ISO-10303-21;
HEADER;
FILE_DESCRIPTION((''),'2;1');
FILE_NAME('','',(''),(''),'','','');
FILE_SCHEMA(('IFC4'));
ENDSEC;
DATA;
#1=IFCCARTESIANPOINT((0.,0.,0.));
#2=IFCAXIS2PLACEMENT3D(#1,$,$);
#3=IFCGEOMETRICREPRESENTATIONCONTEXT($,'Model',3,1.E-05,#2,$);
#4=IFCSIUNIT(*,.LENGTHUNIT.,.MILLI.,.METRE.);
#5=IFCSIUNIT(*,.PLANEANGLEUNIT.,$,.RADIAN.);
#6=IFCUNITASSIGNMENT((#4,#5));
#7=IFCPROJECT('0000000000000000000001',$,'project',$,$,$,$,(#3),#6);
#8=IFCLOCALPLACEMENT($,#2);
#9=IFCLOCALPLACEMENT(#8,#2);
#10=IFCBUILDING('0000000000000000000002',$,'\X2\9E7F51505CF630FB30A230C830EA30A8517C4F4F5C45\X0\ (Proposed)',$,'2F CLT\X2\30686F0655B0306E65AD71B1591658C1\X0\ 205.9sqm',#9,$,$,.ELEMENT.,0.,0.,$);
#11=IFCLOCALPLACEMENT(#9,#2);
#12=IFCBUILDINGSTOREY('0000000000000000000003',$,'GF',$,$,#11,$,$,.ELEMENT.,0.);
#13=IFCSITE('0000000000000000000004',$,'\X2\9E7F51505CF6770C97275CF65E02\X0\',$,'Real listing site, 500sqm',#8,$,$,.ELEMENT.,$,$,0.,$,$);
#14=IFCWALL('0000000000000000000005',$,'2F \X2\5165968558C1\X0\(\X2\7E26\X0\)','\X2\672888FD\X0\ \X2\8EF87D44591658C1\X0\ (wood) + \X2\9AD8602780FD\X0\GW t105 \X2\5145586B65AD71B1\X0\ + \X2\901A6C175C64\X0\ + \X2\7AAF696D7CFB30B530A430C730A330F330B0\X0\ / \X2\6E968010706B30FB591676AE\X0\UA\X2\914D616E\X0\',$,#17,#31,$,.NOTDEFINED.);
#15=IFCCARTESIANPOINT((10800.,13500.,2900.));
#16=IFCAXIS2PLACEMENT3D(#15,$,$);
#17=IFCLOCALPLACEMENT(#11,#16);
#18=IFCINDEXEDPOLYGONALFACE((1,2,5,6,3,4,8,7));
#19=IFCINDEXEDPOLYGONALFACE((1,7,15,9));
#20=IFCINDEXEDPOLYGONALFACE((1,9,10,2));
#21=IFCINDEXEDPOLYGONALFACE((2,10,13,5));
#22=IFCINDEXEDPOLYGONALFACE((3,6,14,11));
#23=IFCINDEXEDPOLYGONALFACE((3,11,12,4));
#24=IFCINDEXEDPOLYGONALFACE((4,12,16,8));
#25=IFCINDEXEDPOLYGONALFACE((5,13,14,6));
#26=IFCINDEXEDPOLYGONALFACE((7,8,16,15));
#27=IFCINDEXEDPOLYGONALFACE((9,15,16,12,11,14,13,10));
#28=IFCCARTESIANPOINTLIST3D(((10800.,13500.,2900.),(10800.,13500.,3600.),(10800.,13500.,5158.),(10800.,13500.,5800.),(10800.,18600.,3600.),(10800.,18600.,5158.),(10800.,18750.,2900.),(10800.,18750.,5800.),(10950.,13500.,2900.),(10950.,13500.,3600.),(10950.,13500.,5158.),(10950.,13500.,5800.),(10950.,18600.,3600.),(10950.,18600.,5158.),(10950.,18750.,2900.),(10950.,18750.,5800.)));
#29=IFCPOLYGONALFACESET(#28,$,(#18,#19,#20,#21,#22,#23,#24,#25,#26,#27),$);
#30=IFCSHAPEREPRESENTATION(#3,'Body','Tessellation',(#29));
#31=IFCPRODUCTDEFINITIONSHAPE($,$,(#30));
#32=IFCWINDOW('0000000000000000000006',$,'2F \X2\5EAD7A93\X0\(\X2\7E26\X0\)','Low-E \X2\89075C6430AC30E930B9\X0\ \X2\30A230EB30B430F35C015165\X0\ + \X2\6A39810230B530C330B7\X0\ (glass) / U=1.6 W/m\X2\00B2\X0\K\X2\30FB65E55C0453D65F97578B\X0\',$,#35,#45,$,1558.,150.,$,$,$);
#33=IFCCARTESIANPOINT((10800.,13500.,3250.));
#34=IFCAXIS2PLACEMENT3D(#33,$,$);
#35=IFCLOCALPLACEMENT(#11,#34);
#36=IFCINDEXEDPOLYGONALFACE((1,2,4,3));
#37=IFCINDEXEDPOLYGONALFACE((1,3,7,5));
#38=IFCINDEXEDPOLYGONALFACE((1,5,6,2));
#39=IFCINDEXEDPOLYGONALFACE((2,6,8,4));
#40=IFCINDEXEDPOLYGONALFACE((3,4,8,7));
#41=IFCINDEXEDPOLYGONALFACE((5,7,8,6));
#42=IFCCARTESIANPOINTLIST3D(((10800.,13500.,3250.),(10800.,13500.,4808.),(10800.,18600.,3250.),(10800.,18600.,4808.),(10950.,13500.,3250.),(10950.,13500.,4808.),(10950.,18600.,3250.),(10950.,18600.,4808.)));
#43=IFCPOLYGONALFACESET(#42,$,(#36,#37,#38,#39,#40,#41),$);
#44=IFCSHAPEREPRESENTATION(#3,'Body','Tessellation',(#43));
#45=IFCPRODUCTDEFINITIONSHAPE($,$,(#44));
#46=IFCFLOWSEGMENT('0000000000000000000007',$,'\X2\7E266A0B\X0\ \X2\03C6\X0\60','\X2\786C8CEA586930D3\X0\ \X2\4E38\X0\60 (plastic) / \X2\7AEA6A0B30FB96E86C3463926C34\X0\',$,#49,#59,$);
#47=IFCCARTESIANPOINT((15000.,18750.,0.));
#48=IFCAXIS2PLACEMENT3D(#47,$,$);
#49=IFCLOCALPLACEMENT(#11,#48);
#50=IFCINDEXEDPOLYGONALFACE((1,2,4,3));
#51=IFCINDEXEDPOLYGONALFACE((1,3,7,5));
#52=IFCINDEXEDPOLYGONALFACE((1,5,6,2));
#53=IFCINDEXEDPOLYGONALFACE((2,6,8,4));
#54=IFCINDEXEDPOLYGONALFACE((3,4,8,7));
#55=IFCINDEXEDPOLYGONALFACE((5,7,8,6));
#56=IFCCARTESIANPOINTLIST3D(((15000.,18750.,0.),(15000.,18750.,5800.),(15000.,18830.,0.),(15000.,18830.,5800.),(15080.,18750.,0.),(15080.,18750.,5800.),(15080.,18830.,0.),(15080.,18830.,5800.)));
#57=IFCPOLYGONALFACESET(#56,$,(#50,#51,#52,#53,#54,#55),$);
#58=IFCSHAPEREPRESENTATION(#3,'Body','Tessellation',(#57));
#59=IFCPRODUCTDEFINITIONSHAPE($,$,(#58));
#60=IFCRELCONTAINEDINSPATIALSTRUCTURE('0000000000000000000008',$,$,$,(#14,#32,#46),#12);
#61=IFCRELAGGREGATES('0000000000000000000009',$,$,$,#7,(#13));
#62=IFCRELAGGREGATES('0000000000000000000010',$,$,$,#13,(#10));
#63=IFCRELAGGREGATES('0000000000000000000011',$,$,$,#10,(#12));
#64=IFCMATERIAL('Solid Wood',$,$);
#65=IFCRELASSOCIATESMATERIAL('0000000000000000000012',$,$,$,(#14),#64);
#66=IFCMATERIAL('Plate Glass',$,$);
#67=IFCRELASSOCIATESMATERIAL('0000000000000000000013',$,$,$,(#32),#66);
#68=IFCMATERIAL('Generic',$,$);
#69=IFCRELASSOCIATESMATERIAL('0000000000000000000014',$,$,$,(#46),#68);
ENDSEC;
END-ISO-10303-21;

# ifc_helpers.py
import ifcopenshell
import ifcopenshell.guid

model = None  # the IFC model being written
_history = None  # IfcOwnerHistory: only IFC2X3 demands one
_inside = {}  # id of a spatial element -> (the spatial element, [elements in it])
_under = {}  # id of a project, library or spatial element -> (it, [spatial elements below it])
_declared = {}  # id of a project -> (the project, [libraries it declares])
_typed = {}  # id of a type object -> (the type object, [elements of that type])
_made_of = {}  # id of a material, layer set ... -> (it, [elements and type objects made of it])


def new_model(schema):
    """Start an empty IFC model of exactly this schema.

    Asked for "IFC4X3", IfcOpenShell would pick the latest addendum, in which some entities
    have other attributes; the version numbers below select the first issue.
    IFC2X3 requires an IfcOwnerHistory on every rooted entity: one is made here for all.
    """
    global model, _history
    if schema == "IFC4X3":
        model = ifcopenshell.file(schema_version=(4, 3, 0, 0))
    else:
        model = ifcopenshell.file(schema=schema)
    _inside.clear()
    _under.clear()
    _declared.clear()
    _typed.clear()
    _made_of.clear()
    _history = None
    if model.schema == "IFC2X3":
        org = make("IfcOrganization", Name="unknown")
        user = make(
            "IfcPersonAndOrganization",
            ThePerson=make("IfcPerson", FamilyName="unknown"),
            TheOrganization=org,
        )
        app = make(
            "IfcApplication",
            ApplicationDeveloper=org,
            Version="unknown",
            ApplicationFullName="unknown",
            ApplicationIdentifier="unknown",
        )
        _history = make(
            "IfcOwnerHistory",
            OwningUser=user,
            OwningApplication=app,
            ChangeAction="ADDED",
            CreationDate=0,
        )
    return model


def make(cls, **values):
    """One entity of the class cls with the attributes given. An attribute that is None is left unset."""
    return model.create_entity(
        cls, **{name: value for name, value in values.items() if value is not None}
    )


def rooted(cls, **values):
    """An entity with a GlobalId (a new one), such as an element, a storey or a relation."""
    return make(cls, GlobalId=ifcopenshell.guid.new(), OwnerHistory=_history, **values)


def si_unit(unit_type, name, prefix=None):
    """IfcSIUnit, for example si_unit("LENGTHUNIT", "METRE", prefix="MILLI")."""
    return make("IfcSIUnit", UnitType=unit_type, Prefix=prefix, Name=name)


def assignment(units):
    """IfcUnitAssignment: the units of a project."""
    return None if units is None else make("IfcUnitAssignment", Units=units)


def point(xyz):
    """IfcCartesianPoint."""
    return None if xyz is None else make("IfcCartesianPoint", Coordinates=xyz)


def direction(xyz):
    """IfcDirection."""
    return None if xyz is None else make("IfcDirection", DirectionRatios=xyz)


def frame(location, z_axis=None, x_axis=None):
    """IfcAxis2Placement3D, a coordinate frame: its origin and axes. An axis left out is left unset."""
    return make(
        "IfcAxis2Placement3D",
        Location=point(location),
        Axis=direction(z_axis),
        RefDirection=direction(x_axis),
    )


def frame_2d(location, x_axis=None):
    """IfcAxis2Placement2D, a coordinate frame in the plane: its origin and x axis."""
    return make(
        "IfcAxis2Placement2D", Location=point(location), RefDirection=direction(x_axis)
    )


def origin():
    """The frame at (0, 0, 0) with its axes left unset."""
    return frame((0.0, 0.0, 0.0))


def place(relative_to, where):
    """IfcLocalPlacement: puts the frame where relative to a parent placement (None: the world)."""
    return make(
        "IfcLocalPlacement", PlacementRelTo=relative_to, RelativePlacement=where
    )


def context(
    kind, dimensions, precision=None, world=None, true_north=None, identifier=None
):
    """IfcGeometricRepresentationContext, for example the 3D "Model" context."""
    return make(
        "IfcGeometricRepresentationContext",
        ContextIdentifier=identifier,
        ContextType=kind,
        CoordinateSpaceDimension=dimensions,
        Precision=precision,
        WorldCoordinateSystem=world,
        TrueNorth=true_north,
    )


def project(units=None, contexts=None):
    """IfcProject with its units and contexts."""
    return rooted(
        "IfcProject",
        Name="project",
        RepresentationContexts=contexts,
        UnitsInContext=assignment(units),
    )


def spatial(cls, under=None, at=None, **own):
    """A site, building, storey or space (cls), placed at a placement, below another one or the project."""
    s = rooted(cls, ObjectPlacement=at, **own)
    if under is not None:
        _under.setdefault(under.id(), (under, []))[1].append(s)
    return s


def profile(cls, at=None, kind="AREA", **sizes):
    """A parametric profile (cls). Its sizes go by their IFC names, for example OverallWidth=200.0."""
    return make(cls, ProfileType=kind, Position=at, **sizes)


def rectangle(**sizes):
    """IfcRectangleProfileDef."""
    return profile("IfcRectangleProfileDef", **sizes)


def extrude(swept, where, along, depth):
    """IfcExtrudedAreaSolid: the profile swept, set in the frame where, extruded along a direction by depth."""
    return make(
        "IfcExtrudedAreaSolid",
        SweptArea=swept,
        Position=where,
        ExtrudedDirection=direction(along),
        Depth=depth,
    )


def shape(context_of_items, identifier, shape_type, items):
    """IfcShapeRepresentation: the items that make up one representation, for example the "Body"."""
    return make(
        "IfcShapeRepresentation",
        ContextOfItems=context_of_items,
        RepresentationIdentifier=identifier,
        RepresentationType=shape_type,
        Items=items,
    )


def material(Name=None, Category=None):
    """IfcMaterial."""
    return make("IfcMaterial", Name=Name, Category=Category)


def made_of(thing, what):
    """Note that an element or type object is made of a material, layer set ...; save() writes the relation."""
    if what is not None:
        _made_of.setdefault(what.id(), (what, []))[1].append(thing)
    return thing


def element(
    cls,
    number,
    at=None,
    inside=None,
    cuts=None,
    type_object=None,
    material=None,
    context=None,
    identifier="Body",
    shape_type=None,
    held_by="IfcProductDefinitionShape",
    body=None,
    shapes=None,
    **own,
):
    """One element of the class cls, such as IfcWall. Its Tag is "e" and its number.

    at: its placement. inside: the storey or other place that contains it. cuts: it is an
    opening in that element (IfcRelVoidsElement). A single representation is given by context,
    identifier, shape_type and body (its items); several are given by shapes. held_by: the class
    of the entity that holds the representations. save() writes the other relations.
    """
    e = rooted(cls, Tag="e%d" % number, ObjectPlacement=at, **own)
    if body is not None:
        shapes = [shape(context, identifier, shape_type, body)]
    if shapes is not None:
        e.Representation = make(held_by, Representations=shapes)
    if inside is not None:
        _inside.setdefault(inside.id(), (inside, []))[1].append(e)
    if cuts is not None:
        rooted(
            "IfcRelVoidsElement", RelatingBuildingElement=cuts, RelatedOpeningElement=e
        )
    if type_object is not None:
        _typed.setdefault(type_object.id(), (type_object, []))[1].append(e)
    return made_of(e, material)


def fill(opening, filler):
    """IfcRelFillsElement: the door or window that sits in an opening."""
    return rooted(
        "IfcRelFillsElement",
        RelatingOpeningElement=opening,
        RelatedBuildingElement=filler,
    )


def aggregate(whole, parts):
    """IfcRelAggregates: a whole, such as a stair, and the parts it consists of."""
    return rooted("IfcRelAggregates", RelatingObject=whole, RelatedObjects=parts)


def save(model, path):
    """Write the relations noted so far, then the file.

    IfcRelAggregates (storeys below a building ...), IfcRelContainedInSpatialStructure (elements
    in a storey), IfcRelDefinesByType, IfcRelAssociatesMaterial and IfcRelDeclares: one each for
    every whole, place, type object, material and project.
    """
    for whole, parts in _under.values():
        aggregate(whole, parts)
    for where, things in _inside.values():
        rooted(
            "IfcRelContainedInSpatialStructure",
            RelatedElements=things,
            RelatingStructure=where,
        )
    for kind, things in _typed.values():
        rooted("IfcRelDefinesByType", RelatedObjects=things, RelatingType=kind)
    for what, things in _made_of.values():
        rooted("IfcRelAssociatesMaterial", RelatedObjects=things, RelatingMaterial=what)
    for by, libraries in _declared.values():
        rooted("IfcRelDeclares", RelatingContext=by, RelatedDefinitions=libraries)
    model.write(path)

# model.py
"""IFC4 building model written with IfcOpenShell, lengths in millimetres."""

from ifc_helpers import new_model, si_unit, frame, frame_2d, origin, place, context, project, spatial, rectangle, extrude, material, element, fill, save


model = new_model("IFC4")

# Units and contexts
model_context = context("Model", 3, precision=1e-05, world=origin())
ifc_project = project(units=[si_unit("LENGTHUNIT", "METRE", prefix="MILLI"), si_unit("PLANEANGLEUNIT", "RADIAN")], contexts=[model_context])

# Site, building, storey
site_placement = place(None, origin())
site = spatial("IfcSite", under=ifc_project, at=site_placement, Name="鹿児島県霧島市", ObjectType="Real listing site, 500sqm", CompositionType="ELEMENT", RefElevation=0.0)
building_placement = place(site_placement, origin())
building = spatial("IfcBuilding", under=site, at=building_placement, Name="鹿児島・アトリエ兼住居 (Proposed)", ObjectType="2F CLTと漆喰の断熱外壁 205.9sqm", CompositionType="ELEMENT", ElevationOfRefHeight=0.0, ElevationOfTerrain=0.0)
storey_placement = place(building_placement, origin())
storey = spatial("IfcBuildingStorey", under=building, at=storey_placement, Name="GF", CompositionType="ELEMENT", Elevation=0.0)

# Shared definitions
ifc_material_1 = material(Name="Solid Wood")

# Shared definitions
ifc_material_2 = material(Name="Plate Glass")

# Wall, opening, window
wall_1_placement = place(storey_placement, frame((10800.0, 13500.0, 2900.0)))
wall_1 = element("IfcWall", 1, at=wall_1_placement, inside=storey, material=ifc_material_1, Name="2F 入隅壁(縦)", Description="木製 軸組外壁 (wood) + 高性能GW t105 充填断熱 + 通気層 + 窯業系サイディング / 準耐火・外皮UA配慮", PredefinedType="NOTDEFINED", context=model_context, shape_type="SweptSolid", body=[
    extrude(rectangle(XDim=150.0, YDim=5250.0, at=frame_2d((75.0, 2625.0))), frame((10800.0, 13500.0, 2900.0)), (0.0, 0.0, 1.0), 2900.0),
])
opening_1_placement = place(storey_placement, frame((10800.0, 13500.0, 3250.0)))
opening_1 = element("IfcOpeningElement", 2, at=opening_1_placement, cuts=wall_1, PredefinedType="NOTDEFINED", context=model_context, shape_type="SweptSolid", body=[
    extrude(rectangle(XDim=150.0, YDim=5100.0, at=frame_2d((75.0, 2550.0))), frame((10800.0, 13500.0, 3250.0)), (0.0, 0.0, 1.0), 1558.0),
])
window_1_placement = place(storey_placement, frame((10800.0, 13500.0, 3250.0)))
window_1 = element("IfcWindow", 3, at=window_1_placement, inside=storey, material=ifc_material_2, Name="2F 庭窓(縦)", Description="Low-E 複層ガラス アルゴン封入 + 樹脂サッシ (glass) / U=1.6 W/m²K・日射取得型", OverallHeight=1558.0, OverallWidth=150.0, context=model_context, shape_type="SweptSolid", body=[
    extrude(rectangle(XDim=150.0, YDim=5100.0, at=frame_2d((75.0, 2550.0))), frame((10800.0, 13500.0, 3250.0)), (0.0, 0.0, 1.0), 1558.0),
])
fill(opening_1, window_1)

# Flow segment
ifc_material_3 = material(Name="Generic")
flow_segment_placement = place(storey_placement, frame((15000.0, 18750.0, 0.0)))
element("IfcFlowSegment", 4, at=flow_segment_placement, inside=storey, material=ifc_material_3, Name="縦樋 φ60", Description="硬質塩ビ 丸60 (plastic) / 竪樋・雨水排水", context=model_context, shape_type="SweptSolid", body=[
    extrude(rectangle(XDim=80.0, YDim=80.0, at=frame_2d((40.0, 40.0))), frame((15000.0, 18750.0, 0.0)), (0.0, 0.0, 1.0), 5800.0),
])

save(model, "model.ifc")
